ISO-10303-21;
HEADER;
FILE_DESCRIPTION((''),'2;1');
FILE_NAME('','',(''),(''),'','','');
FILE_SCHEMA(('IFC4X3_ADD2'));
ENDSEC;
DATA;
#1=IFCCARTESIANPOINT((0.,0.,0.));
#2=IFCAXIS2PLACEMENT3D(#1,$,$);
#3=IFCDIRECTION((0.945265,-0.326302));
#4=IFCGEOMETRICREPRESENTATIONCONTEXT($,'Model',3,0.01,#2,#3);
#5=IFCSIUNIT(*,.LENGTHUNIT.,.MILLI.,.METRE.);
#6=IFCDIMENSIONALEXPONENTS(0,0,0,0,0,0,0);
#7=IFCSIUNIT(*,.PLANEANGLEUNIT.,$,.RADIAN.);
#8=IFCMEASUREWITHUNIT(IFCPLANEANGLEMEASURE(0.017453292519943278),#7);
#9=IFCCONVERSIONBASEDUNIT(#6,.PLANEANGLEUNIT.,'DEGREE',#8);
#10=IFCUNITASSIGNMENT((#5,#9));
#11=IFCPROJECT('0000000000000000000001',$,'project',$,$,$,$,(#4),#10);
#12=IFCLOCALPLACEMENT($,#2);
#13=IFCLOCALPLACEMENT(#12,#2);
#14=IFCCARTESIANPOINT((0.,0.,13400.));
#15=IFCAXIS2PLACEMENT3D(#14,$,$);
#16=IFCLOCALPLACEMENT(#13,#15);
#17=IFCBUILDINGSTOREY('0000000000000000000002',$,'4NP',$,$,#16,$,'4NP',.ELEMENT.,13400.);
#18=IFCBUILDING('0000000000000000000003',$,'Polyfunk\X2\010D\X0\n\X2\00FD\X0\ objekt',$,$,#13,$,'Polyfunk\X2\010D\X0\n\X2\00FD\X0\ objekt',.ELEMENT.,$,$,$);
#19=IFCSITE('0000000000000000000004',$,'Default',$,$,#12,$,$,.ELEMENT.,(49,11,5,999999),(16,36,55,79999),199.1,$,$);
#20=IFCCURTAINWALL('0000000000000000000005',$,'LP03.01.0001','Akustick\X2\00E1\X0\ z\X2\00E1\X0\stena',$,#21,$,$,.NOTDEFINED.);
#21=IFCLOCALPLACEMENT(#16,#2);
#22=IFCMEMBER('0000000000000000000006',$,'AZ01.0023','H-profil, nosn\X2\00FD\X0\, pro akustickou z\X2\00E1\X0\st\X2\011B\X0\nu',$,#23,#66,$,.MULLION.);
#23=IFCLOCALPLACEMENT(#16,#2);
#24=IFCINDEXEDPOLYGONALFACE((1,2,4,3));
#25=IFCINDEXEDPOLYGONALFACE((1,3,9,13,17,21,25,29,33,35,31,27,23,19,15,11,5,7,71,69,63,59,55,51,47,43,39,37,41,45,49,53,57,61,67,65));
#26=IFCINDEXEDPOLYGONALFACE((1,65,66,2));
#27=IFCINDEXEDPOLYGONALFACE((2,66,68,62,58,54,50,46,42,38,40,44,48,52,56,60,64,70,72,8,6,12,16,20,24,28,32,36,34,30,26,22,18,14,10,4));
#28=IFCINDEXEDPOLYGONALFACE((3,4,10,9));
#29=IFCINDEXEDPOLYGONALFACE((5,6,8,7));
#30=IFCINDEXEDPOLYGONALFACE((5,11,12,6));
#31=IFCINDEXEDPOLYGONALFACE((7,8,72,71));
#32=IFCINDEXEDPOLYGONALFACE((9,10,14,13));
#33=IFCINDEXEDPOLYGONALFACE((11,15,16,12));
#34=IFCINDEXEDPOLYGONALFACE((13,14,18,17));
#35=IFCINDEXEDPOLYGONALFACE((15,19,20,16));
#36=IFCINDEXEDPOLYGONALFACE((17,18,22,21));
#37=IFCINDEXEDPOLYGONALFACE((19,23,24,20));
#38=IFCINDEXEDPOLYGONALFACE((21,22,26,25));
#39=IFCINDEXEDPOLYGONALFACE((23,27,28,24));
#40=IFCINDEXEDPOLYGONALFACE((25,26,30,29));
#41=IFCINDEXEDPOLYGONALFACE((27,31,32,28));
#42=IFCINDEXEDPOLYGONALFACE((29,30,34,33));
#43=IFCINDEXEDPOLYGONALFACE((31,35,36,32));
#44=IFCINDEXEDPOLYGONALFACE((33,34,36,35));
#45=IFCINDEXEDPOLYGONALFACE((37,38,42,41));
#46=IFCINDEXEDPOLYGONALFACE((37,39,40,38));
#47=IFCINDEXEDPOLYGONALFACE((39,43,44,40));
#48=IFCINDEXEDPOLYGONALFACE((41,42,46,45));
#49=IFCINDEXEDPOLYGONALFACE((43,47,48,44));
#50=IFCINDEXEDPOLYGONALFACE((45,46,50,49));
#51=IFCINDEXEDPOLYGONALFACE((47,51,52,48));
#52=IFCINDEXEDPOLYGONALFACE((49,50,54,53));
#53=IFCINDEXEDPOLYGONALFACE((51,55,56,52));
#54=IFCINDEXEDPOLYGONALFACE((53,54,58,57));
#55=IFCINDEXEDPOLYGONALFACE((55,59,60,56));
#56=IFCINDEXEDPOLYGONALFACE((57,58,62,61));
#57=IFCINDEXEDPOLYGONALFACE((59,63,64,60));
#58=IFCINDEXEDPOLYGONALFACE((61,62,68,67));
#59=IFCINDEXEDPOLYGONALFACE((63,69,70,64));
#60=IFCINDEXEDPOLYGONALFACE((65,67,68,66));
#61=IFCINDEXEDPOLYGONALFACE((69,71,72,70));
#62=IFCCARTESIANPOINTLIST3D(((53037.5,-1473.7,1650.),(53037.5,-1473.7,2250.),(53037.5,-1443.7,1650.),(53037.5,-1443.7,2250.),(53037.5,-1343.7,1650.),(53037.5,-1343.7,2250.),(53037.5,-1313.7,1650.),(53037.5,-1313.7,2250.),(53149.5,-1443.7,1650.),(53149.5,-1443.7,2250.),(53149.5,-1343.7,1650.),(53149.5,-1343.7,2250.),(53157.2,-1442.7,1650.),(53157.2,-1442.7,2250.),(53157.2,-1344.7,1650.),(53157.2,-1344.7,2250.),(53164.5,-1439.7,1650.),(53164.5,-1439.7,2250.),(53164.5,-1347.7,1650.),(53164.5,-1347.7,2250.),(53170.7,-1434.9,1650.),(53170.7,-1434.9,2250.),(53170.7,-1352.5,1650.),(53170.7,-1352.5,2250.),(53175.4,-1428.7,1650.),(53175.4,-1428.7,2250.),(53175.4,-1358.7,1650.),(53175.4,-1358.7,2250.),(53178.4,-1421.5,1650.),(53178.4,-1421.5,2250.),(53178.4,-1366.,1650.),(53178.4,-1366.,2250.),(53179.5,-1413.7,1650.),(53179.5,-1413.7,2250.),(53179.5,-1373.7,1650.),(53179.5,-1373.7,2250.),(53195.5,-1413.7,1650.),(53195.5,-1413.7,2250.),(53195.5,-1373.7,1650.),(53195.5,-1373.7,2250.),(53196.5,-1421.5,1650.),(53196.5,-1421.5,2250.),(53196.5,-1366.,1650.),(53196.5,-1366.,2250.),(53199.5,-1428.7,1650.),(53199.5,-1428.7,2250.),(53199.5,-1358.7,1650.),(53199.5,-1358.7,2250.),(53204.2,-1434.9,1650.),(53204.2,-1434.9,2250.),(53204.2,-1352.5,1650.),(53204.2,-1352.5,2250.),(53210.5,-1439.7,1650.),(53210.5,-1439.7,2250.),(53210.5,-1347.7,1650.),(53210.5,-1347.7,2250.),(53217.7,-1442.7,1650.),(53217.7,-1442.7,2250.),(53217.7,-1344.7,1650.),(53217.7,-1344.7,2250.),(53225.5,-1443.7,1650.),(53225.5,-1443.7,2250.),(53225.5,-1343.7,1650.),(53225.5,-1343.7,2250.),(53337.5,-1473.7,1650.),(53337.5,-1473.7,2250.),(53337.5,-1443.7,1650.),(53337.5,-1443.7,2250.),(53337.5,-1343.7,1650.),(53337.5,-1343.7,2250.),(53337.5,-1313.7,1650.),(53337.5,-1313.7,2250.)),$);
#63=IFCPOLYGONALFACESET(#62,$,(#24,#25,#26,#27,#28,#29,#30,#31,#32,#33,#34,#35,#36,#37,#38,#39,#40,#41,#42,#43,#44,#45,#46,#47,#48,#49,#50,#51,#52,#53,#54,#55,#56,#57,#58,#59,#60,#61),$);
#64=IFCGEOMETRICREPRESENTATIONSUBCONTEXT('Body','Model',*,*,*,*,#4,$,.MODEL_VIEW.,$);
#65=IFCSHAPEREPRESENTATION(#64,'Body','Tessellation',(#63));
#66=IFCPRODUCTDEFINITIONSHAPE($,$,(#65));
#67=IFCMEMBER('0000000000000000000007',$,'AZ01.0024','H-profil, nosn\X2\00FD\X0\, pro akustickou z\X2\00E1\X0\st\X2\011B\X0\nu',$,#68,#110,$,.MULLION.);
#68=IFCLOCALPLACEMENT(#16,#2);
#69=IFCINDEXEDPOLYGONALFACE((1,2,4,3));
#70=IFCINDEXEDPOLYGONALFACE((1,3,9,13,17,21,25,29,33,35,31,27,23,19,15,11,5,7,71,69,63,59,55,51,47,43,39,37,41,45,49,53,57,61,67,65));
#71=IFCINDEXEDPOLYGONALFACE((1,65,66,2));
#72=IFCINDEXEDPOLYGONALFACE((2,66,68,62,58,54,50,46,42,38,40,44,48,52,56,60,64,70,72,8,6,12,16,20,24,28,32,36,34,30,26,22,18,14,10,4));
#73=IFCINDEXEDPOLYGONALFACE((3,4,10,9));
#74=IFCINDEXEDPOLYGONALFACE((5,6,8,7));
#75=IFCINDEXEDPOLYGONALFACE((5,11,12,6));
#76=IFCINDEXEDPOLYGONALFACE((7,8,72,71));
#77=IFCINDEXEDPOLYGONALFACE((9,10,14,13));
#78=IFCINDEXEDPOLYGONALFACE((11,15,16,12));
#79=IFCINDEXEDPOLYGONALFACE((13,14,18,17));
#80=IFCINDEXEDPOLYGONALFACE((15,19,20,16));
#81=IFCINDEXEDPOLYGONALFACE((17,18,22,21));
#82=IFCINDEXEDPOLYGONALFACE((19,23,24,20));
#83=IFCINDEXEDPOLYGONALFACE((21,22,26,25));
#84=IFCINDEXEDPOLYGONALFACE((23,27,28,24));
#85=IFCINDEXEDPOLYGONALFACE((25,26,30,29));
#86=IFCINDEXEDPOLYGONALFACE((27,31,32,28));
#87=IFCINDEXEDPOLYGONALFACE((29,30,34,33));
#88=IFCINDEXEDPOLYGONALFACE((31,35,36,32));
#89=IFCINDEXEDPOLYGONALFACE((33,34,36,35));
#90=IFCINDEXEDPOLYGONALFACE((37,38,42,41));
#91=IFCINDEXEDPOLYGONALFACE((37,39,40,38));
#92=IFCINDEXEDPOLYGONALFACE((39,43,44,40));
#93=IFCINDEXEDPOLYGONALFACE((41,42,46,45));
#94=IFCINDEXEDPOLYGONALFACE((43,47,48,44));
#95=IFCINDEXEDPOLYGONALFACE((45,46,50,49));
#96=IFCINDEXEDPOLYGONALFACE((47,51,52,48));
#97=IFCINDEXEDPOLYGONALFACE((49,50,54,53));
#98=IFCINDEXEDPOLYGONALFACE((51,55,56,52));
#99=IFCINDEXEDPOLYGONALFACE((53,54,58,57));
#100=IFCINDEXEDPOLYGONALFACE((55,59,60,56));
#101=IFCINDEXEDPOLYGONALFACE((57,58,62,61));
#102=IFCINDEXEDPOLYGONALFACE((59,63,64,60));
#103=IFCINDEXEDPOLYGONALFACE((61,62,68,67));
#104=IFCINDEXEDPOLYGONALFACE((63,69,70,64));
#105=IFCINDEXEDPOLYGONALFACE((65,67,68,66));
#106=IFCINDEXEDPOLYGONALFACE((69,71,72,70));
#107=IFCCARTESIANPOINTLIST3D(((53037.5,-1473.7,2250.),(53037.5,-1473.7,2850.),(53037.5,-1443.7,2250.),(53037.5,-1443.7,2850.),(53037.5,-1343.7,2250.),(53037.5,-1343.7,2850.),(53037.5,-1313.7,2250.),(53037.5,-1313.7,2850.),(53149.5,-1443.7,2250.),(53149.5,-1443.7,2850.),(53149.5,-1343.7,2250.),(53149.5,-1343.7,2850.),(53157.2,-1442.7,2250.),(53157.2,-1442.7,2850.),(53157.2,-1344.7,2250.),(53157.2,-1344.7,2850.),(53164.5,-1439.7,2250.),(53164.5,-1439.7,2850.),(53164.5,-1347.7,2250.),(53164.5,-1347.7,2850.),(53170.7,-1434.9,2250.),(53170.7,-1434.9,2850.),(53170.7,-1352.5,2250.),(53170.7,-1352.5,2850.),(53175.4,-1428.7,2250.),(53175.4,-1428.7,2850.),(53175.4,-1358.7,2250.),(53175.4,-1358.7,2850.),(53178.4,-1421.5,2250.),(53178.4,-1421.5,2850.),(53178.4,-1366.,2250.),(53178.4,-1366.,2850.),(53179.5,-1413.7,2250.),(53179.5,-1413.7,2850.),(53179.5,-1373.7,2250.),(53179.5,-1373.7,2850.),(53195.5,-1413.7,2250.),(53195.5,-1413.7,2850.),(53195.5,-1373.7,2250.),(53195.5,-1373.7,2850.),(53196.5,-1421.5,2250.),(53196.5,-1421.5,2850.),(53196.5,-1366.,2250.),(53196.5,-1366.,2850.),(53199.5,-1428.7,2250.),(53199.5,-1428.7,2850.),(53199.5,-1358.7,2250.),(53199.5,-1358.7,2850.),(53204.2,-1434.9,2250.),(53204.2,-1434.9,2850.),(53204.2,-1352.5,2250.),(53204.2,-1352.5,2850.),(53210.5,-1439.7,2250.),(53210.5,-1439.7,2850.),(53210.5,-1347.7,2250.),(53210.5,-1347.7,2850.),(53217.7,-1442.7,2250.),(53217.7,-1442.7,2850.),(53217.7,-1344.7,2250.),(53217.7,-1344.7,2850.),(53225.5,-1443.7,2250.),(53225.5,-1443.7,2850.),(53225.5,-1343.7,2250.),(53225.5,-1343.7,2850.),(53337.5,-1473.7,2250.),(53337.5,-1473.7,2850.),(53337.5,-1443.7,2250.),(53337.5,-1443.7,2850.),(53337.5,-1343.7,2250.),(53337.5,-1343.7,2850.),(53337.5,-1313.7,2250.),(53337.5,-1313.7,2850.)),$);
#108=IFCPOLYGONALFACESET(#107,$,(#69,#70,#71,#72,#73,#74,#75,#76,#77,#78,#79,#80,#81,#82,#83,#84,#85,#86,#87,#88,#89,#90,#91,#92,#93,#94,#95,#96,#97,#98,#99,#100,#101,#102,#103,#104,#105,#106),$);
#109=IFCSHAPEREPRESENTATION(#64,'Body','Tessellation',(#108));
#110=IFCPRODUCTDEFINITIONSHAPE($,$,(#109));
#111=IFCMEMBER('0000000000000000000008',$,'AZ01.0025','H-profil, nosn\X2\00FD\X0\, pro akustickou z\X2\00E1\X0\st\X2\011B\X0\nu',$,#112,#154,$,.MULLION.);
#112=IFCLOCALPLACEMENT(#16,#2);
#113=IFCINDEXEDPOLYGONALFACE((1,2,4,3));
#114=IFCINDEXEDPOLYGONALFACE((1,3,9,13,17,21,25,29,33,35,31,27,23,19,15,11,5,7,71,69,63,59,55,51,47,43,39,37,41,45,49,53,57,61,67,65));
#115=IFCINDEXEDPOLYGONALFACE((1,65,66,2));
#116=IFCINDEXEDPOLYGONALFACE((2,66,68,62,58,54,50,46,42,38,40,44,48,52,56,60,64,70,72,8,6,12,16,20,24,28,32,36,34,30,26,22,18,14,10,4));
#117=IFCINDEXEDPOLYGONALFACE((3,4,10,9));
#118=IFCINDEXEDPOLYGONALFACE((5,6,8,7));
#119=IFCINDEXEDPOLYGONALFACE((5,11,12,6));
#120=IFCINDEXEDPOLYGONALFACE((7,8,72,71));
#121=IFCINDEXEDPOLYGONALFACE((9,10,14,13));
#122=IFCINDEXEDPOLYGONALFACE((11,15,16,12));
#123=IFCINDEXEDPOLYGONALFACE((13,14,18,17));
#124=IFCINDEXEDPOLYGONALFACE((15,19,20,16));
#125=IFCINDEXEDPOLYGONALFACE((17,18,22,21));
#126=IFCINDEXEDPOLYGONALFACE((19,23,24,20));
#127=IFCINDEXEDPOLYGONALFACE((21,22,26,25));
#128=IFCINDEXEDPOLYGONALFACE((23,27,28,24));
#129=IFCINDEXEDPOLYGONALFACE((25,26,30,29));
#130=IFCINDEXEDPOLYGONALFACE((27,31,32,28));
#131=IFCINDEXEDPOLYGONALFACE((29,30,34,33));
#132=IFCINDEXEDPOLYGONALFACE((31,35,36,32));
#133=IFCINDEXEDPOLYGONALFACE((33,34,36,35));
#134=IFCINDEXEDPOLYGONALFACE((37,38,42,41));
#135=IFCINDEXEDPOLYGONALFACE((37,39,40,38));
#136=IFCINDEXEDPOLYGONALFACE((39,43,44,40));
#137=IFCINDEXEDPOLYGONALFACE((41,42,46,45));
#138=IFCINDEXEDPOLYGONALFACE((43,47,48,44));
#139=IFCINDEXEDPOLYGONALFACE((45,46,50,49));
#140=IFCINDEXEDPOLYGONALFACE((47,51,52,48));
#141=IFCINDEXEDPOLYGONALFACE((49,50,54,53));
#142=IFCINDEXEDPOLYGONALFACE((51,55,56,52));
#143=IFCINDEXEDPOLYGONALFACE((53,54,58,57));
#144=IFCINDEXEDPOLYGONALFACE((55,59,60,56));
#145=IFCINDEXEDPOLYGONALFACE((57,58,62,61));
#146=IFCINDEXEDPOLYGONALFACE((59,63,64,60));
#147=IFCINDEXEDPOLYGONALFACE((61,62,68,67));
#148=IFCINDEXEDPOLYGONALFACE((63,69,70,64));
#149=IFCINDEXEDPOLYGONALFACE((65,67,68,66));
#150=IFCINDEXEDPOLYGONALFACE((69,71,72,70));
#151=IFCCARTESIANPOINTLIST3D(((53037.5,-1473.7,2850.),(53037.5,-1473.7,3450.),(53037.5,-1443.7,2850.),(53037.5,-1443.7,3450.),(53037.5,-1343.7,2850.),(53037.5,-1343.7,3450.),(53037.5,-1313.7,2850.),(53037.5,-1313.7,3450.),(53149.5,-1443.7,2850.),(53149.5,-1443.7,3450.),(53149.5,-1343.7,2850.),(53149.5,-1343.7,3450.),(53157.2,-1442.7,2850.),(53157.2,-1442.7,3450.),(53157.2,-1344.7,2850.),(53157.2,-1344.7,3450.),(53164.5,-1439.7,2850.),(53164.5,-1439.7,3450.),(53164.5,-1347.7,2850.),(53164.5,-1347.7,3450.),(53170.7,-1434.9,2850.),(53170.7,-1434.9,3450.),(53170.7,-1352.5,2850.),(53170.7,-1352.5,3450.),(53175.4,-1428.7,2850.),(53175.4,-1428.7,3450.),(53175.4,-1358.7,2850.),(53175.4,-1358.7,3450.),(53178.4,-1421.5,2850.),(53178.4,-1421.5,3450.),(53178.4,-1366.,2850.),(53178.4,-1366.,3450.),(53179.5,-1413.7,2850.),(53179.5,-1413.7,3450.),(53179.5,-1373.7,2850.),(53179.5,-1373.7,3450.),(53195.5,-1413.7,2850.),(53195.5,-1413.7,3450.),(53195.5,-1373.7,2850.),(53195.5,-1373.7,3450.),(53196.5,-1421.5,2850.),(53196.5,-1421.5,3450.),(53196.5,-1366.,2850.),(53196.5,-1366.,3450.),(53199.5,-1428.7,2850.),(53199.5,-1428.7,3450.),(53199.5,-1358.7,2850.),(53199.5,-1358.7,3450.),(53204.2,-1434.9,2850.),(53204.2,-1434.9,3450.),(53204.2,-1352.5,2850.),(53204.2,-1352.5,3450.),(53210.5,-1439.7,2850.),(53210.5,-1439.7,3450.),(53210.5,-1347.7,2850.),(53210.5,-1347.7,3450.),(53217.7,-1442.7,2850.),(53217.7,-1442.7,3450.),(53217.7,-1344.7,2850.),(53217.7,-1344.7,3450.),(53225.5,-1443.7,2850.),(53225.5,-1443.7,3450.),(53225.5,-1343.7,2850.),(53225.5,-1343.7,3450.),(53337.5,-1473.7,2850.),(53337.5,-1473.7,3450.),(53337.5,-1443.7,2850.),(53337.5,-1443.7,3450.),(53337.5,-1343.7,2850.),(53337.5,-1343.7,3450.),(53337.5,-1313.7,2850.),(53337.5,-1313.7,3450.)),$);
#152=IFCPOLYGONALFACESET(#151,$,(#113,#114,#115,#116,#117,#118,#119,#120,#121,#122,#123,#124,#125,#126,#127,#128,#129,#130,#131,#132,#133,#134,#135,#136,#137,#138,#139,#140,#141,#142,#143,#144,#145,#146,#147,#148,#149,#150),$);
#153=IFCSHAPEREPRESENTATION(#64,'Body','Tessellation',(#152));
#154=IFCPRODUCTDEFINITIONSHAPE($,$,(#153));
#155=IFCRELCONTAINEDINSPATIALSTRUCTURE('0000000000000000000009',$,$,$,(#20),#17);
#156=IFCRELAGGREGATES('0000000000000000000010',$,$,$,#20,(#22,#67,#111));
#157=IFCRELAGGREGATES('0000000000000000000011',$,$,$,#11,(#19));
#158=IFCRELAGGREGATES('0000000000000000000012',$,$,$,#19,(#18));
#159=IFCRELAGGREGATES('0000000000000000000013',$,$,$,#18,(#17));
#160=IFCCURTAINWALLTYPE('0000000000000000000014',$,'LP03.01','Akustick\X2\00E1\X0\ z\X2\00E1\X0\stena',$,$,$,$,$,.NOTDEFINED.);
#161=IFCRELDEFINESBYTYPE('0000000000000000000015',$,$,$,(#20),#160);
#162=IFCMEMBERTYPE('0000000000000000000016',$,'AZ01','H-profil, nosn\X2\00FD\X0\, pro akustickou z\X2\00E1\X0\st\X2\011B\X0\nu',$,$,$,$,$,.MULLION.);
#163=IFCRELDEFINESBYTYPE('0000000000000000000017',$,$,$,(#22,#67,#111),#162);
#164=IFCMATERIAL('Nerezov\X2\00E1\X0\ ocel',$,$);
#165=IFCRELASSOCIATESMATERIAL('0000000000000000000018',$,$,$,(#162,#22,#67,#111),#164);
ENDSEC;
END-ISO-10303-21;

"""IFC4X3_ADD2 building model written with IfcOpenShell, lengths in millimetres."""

from ifc_helpers import new_model, entity, si_unit, converted_unit, direction, frame, frame_2d, origin, place, context, subcontext, project, spatial, polyline, circle_curve, parameter, trimmed, segment, composite_curve, outline, extrude, source, transform, mapped, material, material_profile, profile_set, profile_usage, type_object, element, aggregate, save


model = new_model("IFC4X3_ADD2")

# Units and contexts
model_context = context("Model", 3, precision=0.01, world=origin(), true_north=direction((0.945265, -0.326302)))
body_context = subcontext(model_context, "Body", "Model", "MODEL_VIEW")
ifc_project = project(units=[si_unit("LENGTHUNIT", "METRE", prefix="MILLI"), converted_unit("PLANEANGLEUNIT", "DEGREE", entity("IfcPlaneAngleMeasure", 0.017453292519943278), si_unit("PLANEANGLEUNIT", "RADIAN"), dimensions=[0, 0, 0, 0, 0, 0, 0])], contexts=[model_context])

# Site, building, storey
site_placement = place(None, origin())
site = spatial("IfcSite", under=ifc_project, at=site_placement, Name="Default", CompositionType="ELEMENT", RefLatitude=(49, 11, 5, 999999), RefLongitude=(16, 36, 55, 79999), RefElevation=199.1)
building_placement = place(site_placement, origin())
building = spatial("IfcBuilding", under=site, at=building_placement, Name="Polyfunkčný objekt", LongName="Polyfunkčný objekt", CompositionType="ELEMENT")
storey_placement = place(building_placement, frame((0.0, 0.0, 13400.0)))
storey = spatial("IfcBuildingStorey", under=building, at=storey_placement, Name="4NP", LongName="4NP", CompositionType="ELEMENT", Elevation=13400.0)

# Curtain wall, members
curtain_wall_type_1 = type_object("IfcCurtainWallType", Name="LP03.01", Description="Akustická zástena", PredefinedType="NOTDEFINED")
curtain_wall_1_placement = place(storey_placement, frame((0.0, 0.0, -13400.0)))
curtain_wall_1 = element("IfcCurtainWall", 1, at=curtain_wall_1_placement, inside=storey, type_object=curtain_wall_type_1, Name="LP03.01.0001", Description="Akustická zástena", PredefinedType="NOTDEFINED")
ifc_material_1 = material(Name="Nerezová ocel")
ifc_material_profile = material_profile(ifc_material_1, outline(composite_curve([segment(polyline([(50.0, -150.0), (80.0, -150.0)]), True, "CONTINUOUS"), segment(polyline([(80.0, -150.0), (80.0, 150.0)]), True, "CONTINUOUS"), segment(polyline([(80.0, 150.0), (50.0, 150.0)]), True, "CONTINUOUS"), segment(polyline([(50.0, 150.0), (50.0, 38.0)]), True, "CONTINUOUS"), segment(trimmed(circle_curve(frame_2d((20.0, 38.0), x_axis=(0.0, 1.0)), 30.0), [parameter(180.0)], [parameter(270.0)], True, "PARAMETER"), False, "CONTINUOUS"), segment(polyline([(20.0, 8.0), (-20.0, 8.0)]), True, "CONTINUOUS"), segment(trimmed(circle_curve(frame_2d((-20.0, 38.0), x_axis=(0.0, 1.0)), 30.0), [parameter(90.0)], [parameter(180.0)], True, "PARAMETER"), False, "CONTINUOUS"), segment(polyline([(-50.0, 38.0), (-50.0, 150.0)]), True, "CONTINUOUS"), segment(polyline([(-50.0, 150.0), (-80.0, 150.0)]), True, "CONTINUOUS"), segment(polyline([(-80.0, 150.0), (-80.0, -150.0)]), True, "CONTINUOUS"), segment(polyline([(-80.0, -150.0), (-50.0, -150.0)]), True, "CONTINUOUS"), segment(polyline([(-50.0, -150.0), (-50.0, -38.0)]), True, "CONTINUOUS"), segment(trimmed(circle_curve(frame_2d((-20.0, -38.0), x_axis=(0.0, 1.0)), 30.0), [parameter(0.0)], [parameter(90.0)], True, "PARAMETER"), False, "CONTINUOUS"), segment(polyline([(-20.0, -8.0), (20.0, -8.0)]), True, "CONTINUOUS"), segment(trimmed(circle_curve(frame_2d((20.0, -38.0), x_axis=(0.0, 1.0)), 30.0), [parameter(270.0)], [parameter(0.0)], True, "PARAMETER"), False, "CONTINUOUS"), segment(polyline([(50.0, -38.0), (50.0, -150.0)]), True, "CONTINUOUS")], self_intersect=False)), Name="Profil zástena")
ifc_profile_set = profile_set([ifc_material_profile], Name="Profil zástena")
ifc_profile_usage = profile_usage(ifc_profile_set)
member_type = type_object("IfcMemberType", Name="AZ01", Description="H-profil, nosný, pro akustickou zástěnu", PredefinedType="MULLION", material=ifc_profile_set)
shared_shape_1 = source(origin(), body_context, "Body", "SweptSolid", [
    extrude(outline(composite_curve([segment(polyline([(50.0, -150.0), (80.0, -150.0)]), True, "CONTINUOUS"), segment(polyline([(80.0, -150.0), (80.0, 150.0)]), True, "CONTINUOUS"), segment(polyline([(80.0, 150.0), (50.0, 150.0)]), True, "CONTINUOUS"), segment(polyline([(50.0, 150.0), (50.0, 38.0)]), True, "CONTINUOUS"), segment(trimmed(circle_curve(frame_2d((20.0, 38.0), x_axis=(0.0, 1.0)), 30.0), [parameter(180.0)], [parameter(270.0)], True, "PARAMETER"), False, "CONTINUOUS"), segment(polyline([(20.0, 8.0), (-20.0, 8.0)]), True, "CONTINUOUS"), segment(trimmed(circle_curve(frame_2d((-20.0, 38.0), x_axis=(0.0, 1.0)), 30.0), [parameter(90.0)], [parameter(180.0)], True, "PARAMETER"), False, "CONTINUOUS"), segment(polyline([(-50.0, 38.0), (-50.0, 150.0)]), True, "CONTINUOUS"), segment(polyline([(-50.0, 150.0), (-80.0, 150.0)]), True, "CONTINUOUS"), segment(polyline([(-80.0, 150.0), (-80.0, -150.0)]), True, "CONTINUOUS"), segment(polyline([(-80.0, -150.0), (-50.0, -150.0)]), True, "CONTINUOUS"), segment(polyline([(-50.0, -150.0), (-50.0, -38.0)]), True, "CONTINUOUS"), segment(trimmed(circle_curve(frame_2d((-20.0, -38.0), x_axis=(0.0, 1.0)), 30.0), [parameter(0.0)], [parameter(90.0)], True, "PARAMETER"), False, "CONTINUOUS"), segment(polyline([(-20.0, -8.0), (20.0, -8.0)]), True, "CONTINUOUS"), segment(trimmed(circle_curve(frame_2d((20.0, -38.0), x_axis=(0.0, 1.0)), 30.0), [parameter(270.0)], [parameter(0.0)], True, "PARAMETER"), False, "CONTINUOUS"), segment(polyline([(50.0, -38.0), (50.0, -150.0)]), True, "CONTINUOUS")], self_intersect=False)), frame((0.0, 0.0, -600.0), z_axis=(0.0, 0.0, 1.0), x_axis=(0.0, -1.0, 0.0)), (0.0, 0.0, 1.0), 600.0),
])
member_1_placement = place(curtain_wall_1_placement, frame((53187.5, -1393.7, 15050.0), z_axis=(0.0, 0.0, -1.0), x_axis=(1.0, 0.0, 0.0)))
member_1 = element("IfcMember", 2, at=member_1_placement, type_object=member_type, material=ifc_profile_usage, Name="AZ01.0023", Description="H-profil, nosný, pro akustickou zástěnu", PredefinedType="MULLION", context=body_context, shape_type="MappedRepresentation", body=[
    mapped(shared_shape_1, transform((0.0, 0.0, 0.0), scale=1.0)),
])
member_2_placement = place(curtain_wall_1_placement, frame((53187.5, -1393.7, 15650.0), z_axis=(0.0, 0.0, -1.0), x_axis=(1.0, 0.0, 0.0)))
member_2 = element("IfcMember", 3, at=member_2_placement, type_object=member_type, material=ifc_profile_usage, Name="AZ01.0024", Description="H-profil, nosný, pro akustickou zástěnu", PredefinedType="MULLION", context=body_context, shape_type="MappedRepresentation", body=[
    mapped(shared_shape_1, transform((0.0, 0.0, 0.0), scale=1.0)),
])
member_3_placement = place(curtain_wall_1_placement, frame((53187.5, -1393.7, 16250.0), z_axis=(0.0, 0.0, -1.0), x_axis=(1.0, 0.0, 0.0)))
member_3 = element("IfcMember", 4, at=member_3_placement, type_object=member_type, material=ifc_profile_usage, Name="AZ01.0025", Description="H-profil, nosný, pro akustickou zástěnu", PredefinedType="MULLION", context=body_context, shape_type="MappedRepresentation", body=[
    mapped(shared_shape_1, transform((0.0, 0.0, 0.0), scale=1.0)),
])

aggregate(curtain_wall_1, [member_1, member_2, member_3])

save(model, "model.ifc")
